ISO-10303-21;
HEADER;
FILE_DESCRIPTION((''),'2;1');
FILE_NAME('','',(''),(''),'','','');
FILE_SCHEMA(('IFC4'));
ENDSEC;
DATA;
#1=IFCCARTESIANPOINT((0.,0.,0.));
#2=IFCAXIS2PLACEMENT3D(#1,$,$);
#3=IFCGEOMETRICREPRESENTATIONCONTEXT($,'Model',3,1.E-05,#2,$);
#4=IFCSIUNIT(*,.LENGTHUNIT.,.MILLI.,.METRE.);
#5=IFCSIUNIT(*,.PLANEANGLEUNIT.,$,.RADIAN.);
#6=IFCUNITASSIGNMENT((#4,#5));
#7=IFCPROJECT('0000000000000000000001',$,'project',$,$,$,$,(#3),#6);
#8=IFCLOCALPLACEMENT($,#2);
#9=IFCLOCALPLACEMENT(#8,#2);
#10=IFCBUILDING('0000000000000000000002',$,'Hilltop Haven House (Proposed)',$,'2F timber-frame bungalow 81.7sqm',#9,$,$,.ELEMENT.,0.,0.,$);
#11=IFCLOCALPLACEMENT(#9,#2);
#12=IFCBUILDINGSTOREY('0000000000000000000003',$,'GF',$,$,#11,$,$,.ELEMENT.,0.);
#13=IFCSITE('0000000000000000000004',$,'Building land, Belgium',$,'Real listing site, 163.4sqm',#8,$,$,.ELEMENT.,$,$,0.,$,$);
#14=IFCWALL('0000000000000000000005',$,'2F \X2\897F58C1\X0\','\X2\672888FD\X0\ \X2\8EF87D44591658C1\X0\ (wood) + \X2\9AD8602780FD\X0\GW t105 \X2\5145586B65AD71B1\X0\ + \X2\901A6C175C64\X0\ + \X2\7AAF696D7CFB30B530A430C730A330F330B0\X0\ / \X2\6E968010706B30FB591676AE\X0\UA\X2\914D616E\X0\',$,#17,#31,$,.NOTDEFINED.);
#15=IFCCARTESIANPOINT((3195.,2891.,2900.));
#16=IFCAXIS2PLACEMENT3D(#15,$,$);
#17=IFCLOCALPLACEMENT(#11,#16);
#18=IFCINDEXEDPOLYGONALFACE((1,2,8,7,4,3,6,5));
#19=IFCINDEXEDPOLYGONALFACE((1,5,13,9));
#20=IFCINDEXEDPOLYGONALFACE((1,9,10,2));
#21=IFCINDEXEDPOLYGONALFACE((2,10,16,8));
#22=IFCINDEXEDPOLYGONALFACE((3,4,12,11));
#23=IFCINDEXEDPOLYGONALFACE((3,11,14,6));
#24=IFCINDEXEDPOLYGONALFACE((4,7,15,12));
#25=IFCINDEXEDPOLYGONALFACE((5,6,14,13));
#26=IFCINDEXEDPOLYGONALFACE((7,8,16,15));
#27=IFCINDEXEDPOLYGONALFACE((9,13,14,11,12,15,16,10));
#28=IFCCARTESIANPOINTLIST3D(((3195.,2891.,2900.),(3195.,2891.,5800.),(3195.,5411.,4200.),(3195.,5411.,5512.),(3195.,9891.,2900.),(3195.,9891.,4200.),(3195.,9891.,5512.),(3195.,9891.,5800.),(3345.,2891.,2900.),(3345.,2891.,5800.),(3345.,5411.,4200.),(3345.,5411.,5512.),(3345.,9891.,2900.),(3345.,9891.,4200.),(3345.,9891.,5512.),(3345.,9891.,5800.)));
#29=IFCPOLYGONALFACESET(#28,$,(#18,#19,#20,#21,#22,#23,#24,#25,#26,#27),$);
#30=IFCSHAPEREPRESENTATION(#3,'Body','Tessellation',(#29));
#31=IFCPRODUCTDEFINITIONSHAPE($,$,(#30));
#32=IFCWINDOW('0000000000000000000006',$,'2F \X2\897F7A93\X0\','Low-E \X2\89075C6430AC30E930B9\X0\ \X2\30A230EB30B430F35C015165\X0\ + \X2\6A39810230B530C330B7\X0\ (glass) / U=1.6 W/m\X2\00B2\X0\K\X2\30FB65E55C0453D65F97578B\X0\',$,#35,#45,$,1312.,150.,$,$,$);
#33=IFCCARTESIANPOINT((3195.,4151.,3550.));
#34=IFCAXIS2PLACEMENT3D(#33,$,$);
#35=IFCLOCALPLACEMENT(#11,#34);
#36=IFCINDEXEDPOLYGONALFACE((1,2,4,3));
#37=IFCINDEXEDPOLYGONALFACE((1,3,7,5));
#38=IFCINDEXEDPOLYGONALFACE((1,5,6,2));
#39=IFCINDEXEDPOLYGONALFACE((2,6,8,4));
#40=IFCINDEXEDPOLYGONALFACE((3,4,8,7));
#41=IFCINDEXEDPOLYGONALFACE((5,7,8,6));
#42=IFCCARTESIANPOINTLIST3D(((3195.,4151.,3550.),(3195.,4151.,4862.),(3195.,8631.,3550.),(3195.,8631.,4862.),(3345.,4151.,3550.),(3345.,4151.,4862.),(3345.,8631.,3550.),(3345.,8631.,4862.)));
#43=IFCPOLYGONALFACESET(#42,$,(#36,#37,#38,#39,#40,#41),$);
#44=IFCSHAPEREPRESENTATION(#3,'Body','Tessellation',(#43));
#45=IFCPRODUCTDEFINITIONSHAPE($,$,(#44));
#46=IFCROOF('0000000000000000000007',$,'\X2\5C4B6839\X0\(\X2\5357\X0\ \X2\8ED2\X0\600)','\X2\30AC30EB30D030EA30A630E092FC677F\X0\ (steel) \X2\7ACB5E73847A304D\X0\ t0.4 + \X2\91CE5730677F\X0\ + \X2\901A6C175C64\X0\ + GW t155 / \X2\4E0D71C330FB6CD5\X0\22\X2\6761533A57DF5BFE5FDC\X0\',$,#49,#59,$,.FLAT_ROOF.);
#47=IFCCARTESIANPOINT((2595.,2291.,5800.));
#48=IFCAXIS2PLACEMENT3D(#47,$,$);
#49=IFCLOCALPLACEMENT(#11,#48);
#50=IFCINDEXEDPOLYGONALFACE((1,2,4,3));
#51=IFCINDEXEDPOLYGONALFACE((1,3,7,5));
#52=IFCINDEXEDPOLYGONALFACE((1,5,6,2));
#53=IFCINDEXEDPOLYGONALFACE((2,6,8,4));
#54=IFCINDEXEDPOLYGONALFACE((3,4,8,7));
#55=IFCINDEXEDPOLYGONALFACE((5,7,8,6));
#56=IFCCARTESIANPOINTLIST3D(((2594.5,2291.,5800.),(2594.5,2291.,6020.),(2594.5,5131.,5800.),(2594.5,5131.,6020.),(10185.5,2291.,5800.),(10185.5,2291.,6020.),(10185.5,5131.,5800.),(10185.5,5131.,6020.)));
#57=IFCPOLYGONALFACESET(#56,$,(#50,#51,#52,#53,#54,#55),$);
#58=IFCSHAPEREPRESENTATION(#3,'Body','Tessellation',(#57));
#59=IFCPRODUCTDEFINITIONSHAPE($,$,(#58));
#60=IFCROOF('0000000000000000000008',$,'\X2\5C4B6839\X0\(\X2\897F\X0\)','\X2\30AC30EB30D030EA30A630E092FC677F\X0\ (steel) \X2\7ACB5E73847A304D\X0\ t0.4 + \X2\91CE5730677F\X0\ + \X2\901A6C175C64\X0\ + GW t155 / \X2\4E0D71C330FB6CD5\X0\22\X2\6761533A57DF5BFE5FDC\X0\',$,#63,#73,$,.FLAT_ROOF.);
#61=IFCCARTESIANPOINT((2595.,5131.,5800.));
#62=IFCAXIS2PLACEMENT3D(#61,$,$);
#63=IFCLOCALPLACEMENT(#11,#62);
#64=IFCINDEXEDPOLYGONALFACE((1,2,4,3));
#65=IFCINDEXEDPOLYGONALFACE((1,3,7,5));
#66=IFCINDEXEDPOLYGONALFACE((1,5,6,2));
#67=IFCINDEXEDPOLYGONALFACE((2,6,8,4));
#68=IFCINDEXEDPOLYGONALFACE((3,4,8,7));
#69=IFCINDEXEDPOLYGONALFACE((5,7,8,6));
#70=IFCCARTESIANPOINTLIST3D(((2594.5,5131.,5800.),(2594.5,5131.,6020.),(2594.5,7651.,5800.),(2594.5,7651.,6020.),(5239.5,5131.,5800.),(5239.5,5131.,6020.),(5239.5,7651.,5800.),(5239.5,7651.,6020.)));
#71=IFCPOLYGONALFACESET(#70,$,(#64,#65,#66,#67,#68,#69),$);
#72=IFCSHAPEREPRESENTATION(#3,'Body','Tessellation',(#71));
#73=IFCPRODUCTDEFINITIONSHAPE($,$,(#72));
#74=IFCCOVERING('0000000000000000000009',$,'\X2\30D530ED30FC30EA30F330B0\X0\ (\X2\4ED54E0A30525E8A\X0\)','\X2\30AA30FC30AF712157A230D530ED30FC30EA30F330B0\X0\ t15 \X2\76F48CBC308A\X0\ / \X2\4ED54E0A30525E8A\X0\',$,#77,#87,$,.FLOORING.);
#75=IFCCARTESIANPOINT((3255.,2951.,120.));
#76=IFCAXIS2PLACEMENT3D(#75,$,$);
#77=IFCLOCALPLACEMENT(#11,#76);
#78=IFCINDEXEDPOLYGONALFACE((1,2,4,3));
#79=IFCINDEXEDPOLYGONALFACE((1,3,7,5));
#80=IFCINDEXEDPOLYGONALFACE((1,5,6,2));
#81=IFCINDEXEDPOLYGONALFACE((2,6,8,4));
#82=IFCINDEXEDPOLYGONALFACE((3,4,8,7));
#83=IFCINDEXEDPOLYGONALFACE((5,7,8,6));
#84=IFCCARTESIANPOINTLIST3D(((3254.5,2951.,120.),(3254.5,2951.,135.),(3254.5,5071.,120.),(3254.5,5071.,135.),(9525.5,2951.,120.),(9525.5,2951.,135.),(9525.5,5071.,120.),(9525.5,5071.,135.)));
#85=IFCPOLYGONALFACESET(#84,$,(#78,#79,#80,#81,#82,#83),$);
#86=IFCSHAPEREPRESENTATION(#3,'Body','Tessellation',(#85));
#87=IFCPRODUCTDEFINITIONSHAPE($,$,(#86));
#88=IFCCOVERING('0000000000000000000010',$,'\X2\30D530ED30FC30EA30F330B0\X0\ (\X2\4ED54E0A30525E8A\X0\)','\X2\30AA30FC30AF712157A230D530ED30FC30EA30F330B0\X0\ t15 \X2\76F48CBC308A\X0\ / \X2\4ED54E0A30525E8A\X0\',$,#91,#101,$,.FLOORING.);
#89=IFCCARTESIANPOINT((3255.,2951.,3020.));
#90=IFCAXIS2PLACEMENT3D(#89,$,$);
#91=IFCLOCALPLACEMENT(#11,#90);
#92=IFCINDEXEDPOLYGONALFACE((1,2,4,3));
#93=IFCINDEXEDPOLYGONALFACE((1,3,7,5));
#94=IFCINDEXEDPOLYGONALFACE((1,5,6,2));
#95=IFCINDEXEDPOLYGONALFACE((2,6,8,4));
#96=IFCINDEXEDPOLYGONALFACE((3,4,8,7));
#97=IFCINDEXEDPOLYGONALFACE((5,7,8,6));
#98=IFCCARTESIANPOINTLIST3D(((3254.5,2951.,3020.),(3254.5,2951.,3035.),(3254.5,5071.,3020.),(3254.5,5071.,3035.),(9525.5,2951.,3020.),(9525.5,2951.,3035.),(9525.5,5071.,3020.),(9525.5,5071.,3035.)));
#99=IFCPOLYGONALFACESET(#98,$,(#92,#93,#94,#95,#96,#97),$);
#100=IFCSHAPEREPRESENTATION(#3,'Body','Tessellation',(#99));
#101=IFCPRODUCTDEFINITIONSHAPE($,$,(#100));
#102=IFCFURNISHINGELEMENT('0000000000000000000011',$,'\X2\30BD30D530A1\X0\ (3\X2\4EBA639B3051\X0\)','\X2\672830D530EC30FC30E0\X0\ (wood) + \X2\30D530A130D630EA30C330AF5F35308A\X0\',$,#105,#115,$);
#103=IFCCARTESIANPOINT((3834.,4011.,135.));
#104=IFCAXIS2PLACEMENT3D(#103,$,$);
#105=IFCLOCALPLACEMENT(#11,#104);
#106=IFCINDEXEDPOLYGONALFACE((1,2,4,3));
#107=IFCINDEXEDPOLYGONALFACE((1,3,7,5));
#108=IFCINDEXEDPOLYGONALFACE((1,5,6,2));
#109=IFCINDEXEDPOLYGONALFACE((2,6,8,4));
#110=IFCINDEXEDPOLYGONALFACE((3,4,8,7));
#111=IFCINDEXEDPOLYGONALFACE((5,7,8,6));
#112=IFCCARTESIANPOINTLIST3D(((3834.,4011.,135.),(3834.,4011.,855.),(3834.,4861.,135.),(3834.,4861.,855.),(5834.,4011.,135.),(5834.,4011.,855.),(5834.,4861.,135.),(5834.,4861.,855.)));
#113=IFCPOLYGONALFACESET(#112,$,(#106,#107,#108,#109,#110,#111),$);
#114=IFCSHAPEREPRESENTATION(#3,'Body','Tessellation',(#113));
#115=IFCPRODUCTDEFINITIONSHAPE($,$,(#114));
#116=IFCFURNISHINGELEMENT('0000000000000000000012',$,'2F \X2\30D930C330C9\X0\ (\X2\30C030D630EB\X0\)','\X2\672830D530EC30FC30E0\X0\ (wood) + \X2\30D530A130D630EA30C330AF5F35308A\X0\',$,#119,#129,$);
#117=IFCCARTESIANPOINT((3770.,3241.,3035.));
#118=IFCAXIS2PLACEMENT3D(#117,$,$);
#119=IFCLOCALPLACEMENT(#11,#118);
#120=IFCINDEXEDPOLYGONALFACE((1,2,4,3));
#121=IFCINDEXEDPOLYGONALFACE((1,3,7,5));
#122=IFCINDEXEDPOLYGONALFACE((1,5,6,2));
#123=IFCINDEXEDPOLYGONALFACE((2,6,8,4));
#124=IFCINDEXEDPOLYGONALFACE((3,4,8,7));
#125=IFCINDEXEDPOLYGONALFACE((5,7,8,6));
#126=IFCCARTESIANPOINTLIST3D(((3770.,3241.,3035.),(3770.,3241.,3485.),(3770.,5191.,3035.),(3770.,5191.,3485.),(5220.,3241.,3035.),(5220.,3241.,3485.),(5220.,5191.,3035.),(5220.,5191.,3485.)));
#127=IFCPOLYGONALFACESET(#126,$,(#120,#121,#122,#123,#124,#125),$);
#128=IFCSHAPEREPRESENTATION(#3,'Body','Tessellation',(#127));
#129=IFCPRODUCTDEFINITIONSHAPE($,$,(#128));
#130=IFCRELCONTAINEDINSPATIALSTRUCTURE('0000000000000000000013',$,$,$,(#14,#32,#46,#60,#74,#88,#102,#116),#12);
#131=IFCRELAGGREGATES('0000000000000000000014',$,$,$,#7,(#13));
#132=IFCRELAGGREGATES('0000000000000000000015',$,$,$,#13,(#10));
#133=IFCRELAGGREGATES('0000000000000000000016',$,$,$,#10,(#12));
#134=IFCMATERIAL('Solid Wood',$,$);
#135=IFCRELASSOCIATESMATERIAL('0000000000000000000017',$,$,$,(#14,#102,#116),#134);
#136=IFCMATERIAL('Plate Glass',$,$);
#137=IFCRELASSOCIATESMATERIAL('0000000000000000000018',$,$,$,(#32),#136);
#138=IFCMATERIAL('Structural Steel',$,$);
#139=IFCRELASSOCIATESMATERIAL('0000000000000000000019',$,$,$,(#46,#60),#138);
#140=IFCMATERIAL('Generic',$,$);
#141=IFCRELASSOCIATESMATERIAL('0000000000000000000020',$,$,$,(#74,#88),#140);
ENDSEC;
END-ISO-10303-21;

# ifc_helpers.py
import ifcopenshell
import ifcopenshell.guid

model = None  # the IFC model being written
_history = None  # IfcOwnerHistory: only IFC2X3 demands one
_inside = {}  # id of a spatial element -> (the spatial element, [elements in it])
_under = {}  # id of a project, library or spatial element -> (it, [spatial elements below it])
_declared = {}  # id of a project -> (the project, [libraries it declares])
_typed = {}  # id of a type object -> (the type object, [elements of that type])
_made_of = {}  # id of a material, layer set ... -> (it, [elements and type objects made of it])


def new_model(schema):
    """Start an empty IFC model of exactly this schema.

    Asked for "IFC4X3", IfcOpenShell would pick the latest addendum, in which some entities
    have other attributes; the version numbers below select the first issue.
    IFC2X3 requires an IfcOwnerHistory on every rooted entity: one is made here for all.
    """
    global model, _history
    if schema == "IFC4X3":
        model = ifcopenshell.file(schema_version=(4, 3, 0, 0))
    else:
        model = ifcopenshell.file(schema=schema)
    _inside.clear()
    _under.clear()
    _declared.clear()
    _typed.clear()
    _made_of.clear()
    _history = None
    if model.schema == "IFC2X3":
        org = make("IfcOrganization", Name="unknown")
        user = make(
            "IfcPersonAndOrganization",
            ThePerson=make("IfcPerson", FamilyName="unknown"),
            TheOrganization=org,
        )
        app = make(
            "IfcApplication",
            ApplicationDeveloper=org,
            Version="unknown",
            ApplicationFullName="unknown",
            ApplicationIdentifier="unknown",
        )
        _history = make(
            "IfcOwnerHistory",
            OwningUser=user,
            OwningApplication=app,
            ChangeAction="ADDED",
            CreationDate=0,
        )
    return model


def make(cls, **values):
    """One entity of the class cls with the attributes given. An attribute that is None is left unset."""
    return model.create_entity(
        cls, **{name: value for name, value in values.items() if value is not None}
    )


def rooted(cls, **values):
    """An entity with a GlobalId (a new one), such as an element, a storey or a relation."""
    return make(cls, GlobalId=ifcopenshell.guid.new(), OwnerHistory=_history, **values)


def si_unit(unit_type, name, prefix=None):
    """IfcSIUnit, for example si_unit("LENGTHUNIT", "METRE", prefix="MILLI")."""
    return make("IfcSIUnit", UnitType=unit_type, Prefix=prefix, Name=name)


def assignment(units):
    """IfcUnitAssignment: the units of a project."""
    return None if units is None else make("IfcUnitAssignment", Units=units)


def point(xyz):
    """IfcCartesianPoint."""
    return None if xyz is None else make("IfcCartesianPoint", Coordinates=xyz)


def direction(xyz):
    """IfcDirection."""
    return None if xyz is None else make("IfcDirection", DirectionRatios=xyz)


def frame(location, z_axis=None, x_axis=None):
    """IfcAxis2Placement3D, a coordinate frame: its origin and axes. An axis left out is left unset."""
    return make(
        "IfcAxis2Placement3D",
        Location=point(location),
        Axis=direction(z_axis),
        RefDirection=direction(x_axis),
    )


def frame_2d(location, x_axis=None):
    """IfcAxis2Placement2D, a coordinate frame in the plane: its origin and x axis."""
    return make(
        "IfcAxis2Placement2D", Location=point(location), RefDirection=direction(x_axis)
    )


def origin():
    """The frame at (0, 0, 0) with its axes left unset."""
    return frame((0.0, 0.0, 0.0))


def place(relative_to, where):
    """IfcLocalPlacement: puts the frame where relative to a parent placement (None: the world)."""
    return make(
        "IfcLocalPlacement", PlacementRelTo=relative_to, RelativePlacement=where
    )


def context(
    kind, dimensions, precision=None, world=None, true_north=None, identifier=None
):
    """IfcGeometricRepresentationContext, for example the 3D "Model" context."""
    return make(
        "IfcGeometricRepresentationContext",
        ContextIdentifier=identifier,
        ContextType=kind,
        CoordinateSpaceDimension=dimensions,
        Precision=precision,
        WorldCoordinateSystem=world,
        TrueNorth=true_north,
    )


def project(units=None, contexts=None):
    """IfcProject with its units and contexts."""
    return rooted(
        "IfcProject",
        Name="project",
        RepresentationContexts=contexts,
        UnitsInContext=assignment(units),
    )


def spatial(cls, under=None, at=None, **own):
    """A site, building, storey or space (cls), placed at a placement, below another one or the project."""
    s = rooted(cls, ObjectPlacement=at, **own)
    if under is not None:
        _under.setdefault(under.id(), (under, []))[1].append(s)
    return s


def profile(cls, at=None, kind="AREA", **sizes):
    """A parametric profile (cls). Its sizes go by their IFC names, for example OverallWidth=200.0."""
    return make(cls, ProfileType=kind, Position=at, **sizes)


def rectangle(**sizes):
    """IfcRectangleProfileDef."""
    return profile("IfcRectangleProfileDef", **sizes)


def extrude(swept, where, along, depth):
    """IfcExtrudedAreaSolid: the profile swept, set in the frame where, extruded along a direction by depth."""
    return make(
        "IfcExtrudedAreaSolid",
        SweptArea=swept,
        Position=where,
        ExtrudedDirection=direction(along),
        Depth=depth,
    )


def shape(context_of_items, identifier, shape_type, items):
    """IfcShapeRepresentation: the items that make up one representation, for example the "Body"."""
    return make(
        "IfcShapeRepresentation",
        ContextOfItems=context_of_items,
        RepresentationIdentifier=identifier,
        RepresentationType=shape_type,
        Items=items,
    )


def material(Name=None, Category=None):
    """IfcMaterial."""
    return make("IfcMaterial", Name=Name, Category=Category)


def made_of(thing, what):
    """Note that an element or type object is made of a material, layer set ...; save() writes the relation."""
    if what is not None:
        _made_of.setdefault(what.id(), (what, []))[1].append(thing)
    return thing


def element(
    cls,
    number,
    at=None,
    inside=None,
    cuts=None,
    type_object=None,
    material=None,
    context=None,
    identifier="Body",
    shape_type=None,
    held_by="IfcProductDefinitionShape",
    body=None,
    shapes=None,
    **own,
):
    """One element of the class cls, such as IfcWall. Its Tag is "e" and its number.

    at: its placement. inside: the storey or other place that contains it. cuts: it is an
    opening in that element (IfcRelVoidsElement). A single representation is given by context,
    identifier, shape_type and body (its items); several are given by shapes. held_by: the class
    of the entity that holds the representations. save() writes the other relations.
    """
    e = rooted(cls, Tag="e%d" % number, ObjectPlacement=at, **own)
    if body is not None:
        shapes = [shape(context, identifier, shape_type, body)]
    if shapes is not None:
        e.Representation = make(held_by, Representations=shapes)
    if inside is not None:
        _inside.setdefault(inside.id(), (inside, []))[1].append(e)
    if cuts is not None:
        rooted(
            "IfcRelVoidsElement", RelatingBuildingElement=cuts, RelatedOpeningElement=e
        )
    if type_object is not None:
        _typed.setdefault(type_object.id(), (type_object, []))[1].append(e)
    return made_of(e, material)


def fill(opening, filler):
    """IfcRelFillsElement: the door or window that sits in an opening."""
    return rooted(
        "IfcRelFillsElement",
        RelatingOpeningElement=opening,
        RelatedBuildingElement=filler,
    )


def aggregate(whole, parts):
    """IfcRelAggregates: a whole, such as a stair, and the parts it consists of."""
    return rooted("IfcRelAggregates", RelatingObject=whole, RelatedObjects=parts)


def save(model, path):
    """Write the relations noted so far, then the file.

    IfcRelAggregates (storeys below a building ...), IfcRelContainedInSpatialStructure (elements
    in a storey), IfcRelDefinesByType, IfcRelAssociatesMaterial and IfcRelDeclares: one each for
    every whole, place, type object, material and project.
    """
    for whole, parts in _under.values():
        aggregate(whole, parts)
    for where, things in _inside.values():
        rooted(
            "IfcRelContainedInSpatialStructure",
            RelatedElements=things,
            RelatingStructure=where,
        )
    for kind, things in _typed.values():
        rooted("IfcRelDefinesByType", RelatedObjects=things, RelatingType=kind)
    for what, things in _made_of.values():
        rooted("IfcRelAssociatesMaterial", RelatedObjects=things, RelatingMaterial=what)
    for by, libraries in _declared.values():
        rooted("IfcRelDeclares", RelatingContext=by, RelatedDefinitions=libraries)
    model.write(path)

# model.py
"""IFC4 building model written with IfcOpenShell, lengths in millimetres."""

from ifc_helpers import new_model, si_unit, frame, frame_2d, origin, place, context, project, spatial, rectangle, extrude, material, element, fill, save


model = new_model("IFC4")

# Units and contexts
model_context = context("Model", 3, precision=1e-05, world=origin())
ifc_project = project(units=[si_unit("LENGTHUNIT", "METRE", prefix="MILLI"), si_unit("PLANEANGLEUNIT", "RADIAN")], contexts=[model_context])

# Site, building, storey
site_placement = place(None, origin())
site = spatial("IfcSite", under=ifc_project, at=site_placement, Name="Building land, Belgium", ObjectType="Real listing site, 163.4sqm", CompositionType="ELEMENT", RefElevation=0.0)
building_placement = place(site_placement, origin())
building = spatial("IfcBuilding", under=site, at=building_placement, Name="Hilltop Haven House (Proposed)", ObjectType="2F timber-frame bungalow 81.7sqm", CompositionType="ELEMENT", ElevationOfRefHeight=0.0, ElevationOfTerrain=0.0)
storey_placement = place(building_placement, origin())
storey = spatial("IfcBuildingStorey", under=building, at=storey_placement, Name="GF", CompositionType="ELEMENT", Elevation=0.0)

# Shared definitions
ifc_material_1 = material(Name="Solid Wood")

# Shared definitions
ifc_material_2 = material(Name="Plate Glass")

# Wall, opening, window
wall_1_placement = place(storey_placement, frame((3195.0, 2891.0, 2900.0)))
wall_1 = element("IfcWall", 1, at=wall_1_placement, inside=storey, material=ifc_material_1, Name="2F 西壁", Description="木製 軸組外壁 (wood) + 高性能GW t105 充填断熱 + 通気層 + 窯業系サイディング / 準耐火・外皮UA配慮", PredefinedType="NOTDEFINED", context=model_context, shape_type="SweptSolid", body=[
    extrude(rectangle(XDim=150.0, YDim=7000.0, at=frame_2d((75.0, 3500.0))), frame((3195.0, 2891.0, 2900.0)), (0.0, 0.0, 1.0), 2900.0),
])
opening_1_placement = place(storey_placement, frame((3195.0, 4151.0, 3550.0)))
opening_1 = element("IfcOpeningElement", 2, at=opening_1_placement, cuts=wall_1, PredefinedType="NOTDEFINED", context=model_context, shape_type="SweptSolid", body=[
    extrude(rectangle(XDim=150.0, YDim=4480.0, at=frame_2d((75.0, 2240.0))), frame((3195.0, 4151.0, 3550.0)), (0.0, 0.0, 1.0), 1312.0),
])
window_1_placement = place(storey_placement, frame((3195.0, 4151.0, 3550.0)))
window_1 = element("IfcWindow", 3, at=window_1_placement, inside=storey, material=ifc_material_2, Name="2F 西窓", Description="Low-E 複層ガラス アルゴン封入 + 樹脂サッシ (glass) / U=1.6 W/m²K・日射取得型", OverallHeight=1312.0, OverallWidth=150.0, context=model_context, shape_type="SweptSolid", body=[
    extrude(rectangle(XDim=150.0, YDim=4480.0, at=frame_2d((75.0, 2240.0))), frame((3195.0, 4151.0, 3550.0)), (0.0, 0.0, 1.0), 1312.0),
])
fill(opening_1, window_1)

# Roofs
ifc_material_3 = material(Name="Structural Steel")
roof_1_placement = place(storey_placement, frame((2595.0, 2291.0, 5800.0)))
element("IfcRoof", 4, at=roof_1_placement, inside=storey, material=ifc_material_3, Name="屋根(南 軒600)", Description="ガルバリウム鋼板 (steel) 立平葺き t0.4 + 野地板 + 通気層 + GW t155 / 不燃・法22条区域対応", PredefinedType="FLAT_ROOF", context=model_context, shape_type="SweptSolid", body=[
    extrude(rectangle(XDim=7591.0, YDim=2840.0, at=frame_2d((3795.0, 1420.0))), frame((2595.0, 2291.0, 5800.0)), (0.0, 0.0, 1.0), 220.0),
])
roof_2_placement = place(storey_placement, frame((2595.0, 5131.0, 5800.0)))
element("IfcRoof", 5, at=roof_2_placement, inside=storey, material=ifc_material_3, Name="屋根(西)", Description="ガルバリウム鋼板 (steel) 立平葺き t0.4 + 野地板 + 通気層 + GW t155 / 不燃・法22条区域対応", PredefinedType="FLAT_ROOF", context=model_context, shape_type="SweptSolid", body=[
    extrude(rectangle(XDim=2645.0, YDim=2520.0, at=frame_2d((1322.0, 1260.0))), frame((2595.0, 5131.0, 5800.0)), (0.0, 0.0, 1.0), 220.0),
])

# Coverings
ifc_material_4 = material(Name="Generic")
covering_1_placement = place(storey_placement, frame((3255.0, 2951.0, 120.0)))
element("IfcCovering", 6, at=covering_1_placement, inside=storey, material=ifc_material_4, Name="フローリング (仕上げ床)", Description="オーク無垢フローリング t15 直貼り / 仕上げ床", PredefinedType="FLOORING", context=model_context, shape_type="SweptSolid", body=[
    extrude(rectangle(XDim=6271.0, YDim=2120.0, at=frame_2d((3135.0, 1060.0))), frame((3255.0, 2951.0, 120.0)), (0.0, 0.0, 1.0), 15.0),
])
covering_2_placement = place(storey_placement, frame((3255.0, 2951.0, 3020.0)))
element("IfcCovering", 7, at=covering_2_placement, inside=storey, material=ifc_material_4, Name="フローリング (仕上げ床)", Description="オーク無垢フローリング t15 直貼り / 仕上げ床", PredefinedType="FLOORING", context=model_context, shape_type="SweptSolid", body=[
    extrude(rectangle(XDim=6271.0, YDim=2120.0, at=frame_2d((3135.0, 1060.0))), frame((3255.0, 2951.0, 3020.0)), (0.0, 0.0, 1.0), 15.0),
])

# Furnishing elements
furnishing_1_placement = place(storey_placement, frame((3834.0, 4011.0, 135.0)))
element("IfcFurnishingElement", 8, at=furnishing_1_placement, inside=storey, material=ifc_material_1, Name="ソファ (3人掛け)", Description="木フレーム (wood) + ファブリック張り", context=model_context, shape_type="SweptSolid", body=[
    extrude(rectangle(XDim=2000.0, YDim=850.0, at=frame_2d((1000.0, 425.0))), frame((3834.0, 4011.0, 135.0)), (0.0, 0.0, 1.0), 720.0),
])
furnishing_2_placement = place(storey_placement, frame((3770.0, 3241.0, 3035.0)))
element("IfcFurnishingElement", 9, at=furnishing_2_placement, inside=storey, material=ifc_material_1, Name="2F ベッド (ダブル)", Description="木フレーム (wood) + ファブリック張り", context=model_context, shape_type="SweptSolid", body=[
    extrude(rectangle(XDim=1450.0, YDim=1950.0, at=frame_2d((725.0, 975.0))), frame((3770.0, 3241.0, 3035.0)), (0.0, 0.0, 1.0), 450.0),
])

save(model, "model.ifc")
